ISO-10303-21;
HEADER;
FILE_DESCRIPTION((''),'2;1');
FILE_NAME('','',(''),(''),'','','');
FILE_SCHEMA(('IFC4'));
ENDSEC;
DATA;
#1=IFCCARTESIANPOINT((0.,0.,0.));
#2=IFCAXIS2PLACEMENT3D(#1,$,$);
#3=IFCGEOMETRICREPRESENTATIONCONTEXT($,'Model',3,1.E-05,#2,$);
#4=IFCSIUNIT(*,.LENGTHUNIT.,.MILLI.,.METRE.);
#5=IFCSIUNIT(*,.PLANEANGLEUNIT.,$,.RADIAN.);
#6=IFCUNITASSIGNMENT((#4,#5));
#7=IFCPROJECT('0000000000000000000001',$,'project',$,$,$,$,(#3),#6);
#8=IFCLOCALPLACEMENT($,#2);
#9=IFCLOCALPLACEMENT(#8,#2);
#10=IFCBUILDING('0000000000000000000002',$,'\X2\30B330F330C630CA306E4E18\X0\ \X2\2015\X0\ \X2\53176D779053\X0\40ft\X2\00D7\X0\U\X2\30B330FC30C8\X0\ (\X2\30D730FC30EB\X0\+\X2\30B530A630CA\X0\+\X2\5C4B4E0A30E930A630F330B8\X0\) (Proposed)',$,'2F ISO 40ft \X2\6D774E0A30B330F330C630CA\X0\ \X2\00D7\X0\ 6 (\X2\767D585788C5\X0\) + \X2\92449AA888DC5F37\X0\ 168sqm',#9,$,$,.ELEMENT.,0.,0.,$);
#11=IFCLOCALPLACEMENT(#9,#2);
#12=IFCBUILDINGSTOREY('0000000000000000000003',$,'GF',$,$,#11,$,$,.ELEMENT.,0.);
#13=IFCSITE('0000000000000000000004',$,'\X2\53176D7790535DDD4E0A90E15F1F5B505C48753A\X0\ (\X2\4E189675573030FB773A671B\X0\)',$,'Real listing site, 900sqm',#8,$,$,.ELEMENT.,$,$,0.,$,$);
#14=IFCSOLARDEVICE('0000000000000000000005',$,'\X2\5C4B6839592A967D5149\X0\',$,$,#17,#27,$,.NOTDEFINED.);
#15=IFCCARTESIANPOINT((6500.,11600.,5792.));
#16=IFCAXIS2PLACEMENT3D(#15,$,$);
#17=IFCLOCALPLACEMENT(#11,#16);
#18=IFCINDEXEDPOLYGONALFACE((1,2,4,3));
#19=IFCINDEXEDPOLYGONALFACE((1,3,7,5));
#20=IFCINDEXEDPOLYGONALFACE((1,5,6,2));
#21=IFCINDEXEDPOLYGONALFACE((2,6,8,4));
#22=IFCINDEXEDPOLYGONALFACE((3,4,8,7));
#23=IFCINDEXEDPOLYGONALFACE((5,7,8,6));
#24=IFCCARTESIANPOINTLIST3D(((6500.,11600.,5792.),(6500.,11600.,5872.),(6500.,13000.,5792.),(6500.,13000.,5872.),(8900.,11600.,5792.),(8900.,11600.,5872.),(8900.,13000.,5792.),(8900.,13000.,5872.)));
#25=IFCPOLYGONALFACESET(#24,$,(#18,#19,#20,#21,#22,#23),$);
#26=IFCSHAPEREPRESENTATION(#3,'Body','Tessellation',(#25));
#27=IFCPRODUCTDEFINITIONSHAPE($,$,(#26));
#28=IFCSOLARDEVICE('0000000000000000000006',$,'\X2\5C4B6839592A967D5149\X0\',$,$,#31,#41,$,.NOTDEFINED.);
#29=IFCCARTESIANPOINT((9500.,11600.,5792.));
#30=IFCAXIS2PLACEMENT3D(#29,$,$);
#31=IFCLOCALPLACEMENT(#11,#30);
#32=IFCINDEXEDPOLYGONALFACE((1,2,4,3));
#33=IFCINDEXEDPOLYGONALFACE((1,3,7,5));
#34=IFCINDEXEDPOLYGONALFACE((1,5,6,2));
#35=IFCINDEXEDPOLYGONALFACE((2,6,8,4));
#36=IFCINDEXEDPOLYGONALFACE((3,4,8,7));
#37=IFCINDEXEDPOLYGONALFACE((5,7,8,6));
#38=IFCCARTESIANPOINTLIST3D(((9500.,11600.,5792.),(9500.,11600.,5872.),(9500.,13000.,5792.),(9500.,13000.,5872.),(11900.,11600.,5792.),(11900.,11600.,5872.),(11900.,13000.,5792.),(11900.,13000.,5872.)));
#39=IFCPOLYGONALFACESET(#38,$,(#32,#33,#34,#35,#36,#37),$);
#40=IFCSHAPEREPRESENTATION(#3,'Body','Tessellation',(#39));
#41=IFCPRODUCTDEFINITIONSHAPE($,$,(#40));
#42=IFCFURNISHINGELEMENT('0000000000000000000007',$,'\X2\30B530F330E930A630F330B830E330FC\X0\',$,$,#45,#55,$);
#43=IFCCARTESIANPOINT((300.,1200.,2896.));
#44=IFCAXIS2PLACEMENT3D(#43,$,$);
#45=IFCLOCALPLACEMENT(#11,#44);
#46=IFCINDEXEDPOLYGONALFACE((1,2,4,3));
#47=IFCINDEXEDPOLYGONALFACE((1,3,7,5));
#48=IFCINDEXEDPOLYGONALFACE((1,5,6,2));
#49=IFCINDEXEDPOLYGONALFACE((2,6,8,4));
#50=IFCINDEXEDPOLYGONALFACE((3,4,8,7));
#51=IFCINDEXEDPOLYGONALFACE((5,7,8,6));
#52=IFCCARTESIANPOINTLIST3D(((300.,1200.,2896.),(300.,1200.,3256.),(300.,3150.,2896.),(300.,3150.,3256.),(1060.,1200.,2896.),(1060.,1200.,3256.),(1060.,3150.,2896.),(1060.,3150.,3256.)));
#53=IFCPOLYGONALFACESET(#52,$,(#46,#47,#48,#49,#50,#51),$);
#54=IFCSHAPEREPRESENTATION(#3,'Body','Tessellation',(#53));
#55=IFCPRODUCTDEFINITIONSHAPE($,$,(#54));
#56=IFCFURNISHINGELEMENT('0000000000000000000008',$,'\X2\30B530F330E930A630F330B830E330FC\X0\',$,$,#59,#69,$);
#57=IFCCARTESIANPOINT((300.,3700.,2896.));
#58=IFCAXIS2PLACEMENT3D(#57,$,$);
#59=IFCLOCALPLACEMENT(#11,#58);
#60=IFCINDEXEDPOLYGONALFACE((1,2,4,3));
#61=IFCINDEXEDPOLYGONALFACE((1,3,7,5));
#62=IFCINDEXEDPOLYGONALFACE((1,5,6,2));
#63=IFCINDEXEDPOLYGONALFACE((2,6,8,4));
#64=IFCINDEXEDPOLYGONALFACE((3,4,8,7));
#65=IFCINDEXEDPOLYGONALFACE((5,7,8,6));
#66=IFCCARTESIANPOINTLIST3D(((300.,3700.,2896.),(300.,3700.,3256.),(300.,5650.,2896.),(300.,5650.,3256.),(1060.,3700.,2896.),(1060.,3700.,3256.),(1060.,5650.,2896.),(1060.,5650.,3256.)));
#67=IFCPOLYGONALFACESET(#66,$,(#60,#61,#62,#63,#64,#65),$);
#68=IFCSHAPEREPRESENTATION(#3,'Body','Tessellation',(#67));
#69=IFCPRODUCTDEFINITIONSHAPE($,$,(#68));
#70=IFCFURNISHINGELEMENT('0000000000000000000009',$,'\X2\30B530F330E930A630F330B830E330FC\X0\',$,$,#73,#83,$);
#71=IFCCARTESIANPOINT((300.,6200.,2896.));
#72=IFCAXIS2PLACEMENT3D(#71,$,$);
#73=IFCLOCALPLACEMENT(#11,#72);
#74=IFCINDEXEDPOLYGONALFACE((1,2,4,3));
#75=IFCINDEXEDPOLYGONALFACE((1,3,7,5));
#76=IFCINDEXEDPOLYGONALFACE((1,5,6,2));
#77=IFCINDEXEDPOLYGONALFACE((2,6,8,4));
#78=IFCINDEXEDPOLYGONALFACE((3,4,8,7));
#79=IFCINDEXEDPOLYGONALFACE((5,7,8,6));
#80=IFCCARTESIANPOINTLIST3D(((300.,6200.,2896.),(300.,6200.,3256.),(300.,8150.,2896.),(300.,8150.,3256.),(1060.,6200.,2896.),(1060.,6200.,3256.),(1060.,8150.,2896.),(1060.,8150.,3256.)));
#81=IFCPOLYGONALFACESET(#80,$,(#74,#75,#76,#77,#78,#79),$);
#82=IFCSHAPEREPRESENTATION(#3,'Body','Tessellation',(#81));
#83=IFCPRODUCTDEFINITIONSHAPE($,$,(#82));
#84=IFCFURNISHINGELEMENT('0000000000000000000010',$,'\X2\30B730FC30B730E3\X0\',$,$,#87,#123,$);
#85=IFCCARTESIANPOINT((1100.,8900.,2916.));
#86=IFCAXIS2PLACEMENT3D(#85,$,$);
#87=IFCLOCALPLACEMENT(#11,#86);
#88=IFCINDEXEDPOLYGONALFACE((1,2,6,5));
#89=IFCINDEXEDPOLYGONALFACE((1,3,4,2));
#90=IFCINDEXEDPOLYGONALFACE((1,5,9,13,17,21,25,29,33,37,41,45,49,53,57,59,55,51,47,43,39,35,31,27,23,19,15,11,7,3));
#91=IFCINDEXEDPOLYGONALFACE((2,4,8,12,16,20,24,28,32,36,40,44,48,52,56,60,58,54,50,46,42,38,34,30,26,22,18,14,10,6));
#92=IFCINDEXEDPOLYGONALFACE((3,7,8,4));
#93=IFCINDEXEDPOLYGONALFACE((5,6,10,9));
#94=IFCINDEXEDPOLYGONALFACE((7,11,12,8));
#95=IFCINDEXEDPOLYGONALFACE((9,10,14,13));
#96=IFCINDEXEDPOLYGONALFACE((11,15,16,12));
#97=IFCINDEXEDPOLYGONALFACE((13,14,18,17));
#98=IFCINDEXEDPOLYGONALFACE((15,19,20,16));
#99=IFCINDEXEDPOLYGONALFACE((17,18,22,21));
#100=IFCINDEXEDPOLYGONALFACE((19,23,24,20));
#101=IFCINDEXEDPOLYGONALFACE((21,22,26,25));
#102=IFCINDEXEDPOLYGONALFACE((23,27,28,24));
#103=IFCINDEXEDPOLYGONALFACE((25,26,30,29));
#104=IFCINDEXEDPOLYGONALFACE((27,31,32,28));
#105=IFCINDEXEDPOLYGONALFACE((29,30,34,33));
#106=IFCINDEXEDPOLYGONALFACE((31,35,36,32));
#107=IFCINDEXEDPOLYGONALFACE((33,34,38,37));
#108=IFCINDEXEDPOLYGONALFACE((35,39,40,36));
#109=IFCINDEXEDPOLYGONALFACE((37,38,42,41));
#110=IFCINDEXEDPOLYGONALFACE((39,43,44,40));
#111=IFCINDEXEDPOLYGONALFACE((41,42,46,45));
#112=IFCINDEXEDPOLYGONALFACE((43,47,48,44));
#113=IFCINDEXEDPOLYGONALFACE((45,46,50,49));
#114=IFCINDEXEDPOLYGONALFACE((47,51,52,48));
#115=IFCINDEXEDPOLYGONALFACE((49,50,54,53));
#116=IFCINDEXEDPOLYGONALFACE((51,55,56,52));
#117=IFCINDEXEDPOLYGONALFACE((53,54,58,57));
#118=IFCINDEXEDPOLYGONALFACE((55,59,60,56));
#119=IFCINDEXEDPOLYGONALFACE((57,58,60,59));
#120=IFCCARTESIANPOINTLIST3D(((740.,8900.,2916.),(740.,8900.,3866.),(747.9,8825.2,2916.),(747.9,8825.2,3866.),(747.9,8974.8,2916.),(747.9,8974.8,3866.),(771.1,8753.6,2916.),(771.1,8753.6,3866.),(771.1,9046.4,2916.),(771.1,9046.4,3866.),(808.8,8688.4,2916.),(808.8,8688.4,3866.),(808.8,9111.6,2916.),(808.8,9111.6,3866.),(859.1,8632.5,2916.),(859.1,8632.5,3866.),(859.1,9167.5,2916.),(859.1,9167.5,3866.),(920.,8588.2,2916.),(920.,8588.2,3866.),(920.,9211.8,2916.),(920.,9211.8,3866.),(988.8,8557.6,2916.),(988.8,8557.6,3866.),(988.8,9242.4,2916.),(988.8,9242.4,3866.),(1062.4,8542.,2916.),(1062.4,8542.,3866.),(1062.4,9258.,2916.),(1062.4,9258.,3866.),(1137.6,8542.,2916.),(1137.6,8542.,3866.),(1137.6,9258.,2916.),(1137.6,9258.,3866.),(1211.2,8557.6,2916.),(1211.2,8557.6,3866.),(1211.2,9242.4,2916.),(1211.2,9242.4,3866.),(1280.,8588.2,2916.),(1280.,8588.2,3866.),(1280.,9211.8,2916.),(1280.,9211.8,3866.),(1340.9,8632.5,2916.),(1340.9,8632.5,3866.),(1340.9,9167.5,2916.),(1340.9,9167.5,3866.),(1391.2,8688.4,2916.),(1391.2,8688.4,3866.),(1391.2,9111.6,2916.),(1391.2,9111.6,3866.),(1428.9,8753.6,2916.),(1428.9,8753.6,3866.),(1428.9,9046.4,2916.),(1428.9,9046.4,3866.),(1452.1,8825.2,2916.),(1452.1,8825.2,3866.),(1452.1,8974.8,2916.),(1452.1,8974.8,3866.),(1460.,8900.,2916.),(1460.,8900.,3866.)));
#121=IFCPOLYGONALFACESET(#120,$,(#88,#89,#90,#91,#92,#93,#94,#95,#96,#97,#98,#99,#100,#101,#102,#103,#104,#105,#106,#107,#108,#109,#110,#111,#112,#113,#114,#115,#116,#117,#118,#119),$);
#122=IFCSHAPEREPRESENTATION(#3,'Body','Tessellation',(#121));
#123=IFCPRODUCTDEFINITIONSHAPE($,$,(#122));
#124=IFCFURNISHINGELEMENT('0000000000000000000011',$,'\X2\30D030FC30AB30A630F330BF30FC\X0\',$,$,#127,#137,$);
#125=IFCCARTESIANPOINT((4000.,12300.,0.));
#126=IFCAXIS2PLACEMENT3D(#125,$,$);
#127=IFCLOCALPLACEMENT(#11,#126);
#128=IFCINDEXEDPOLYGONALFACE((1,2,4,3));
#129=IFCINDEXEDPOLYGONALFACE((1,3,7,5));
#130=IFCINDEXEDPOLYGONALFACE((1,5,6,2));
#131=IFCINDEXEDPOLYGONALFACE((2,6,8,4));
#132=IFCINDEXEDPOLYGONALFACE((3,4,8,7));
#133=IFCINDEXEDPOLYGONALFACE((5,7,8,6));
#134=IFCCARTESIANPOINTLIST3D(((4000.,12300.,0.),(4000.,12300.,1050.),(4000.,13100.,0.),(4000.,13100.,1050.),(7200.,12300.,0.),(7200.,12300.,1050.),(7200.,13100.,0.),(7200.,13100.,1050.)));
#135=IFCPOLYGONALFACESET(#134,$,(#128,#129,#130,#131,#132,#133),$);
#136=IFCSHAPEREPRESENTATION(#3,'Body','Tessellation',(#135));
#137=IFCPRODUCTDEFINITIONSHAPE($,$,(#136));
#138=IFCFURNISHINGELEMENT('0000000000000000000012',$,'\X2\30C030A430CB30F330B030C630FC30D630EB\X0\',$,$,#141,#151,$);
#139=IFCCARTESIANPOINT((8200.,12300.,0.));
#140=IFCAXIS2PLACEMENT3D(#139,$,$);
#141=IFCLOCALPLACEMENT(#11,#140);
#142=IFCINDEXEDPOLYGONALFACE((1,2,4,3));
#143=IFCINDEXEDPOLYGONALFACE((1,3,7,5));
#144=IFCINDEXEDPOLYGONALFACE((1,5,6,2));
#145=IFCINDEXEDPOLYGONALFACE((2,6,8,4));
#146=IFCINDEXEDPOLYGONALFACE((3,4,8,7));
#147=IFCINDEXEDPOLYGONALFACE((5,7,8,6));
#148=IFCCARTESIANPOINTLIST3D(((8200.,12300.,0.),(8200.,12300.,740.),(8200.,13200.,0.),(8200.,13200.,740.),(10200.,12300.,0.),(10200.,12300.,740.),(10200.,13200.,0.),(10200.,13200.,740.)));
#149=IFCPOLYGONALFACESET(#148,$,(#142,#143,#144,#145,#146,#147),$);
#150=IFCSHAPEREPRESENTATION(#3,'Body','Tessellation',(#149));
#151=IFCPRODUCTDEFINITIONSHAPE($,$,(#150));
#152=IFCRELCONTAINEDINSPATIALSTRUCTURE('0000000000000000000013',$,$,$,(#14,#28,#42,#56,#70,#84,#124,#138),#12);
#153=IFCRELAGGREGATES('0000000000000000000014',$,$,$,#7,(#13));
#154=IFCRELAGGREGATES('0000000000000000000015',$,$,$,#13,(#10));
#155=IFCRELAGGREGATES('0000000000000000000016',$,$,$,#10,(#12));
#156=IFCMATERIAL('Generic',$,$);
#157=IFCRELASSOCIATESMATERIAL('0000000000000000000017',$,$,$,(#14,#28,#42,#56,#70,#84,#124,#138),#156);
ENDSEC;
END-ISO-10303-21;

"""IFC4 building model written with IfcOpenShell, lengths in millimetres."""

from ifc_helpers import new_model, si_unit, frame, frame_2d, origin, origin_2d, place, context, project, spatial, rectangle, circle, extrude, material, element, save


model = new_model("IFC4")

# Units and contexts
model_context = context("Model", 3, precision=1e-05, world=origin())
ifc_project = project(units=[si_unit("LENGTHUNIT", "METRE", prefix="MILLI"), si_unit("PLANEANGLEUNIT", "RADIAN")], contexts=[model_context])

# Site, building, storey
site_placement = place(None, origin())
site = spatial("IfcSite", under=ifc_project, at=site_placement, Name="北海道川上郡弟子屈町 (丘陵地・眺望)", ObjectType="Real listing site, 900sqm", CompositionType="ELEMENT", RefElevation=0.0)
building_placement = place(site_placement, origin())
building = spatial("IfcBuilding", under=site, at=building_placement, Name="コンテナの丘 ― 北海道40ft×Uコート (プール+サウナ+屋上ラウンジ) (Proposed)", ObjectType="2F ISO 40ft 海上コンテナ × 6 (白塗装) + 鉄骨補強 168sqm", CompositionType="ELEMENT", ElevationOfRefHeight=0.0, ElevationOfTerrain=0.0)
storey_placement = place(building_placement, origin())
storey = spatial("IfcBuildingStorey", under=building, at=storey_placement, Name="GF", CompositionType="ELEMENT", Elevation=0.0)

# Shared definitions
ifc_material = material(Name="Generic")

# Solar devices
solar_device_1_placement = place(storey_placement, frame((6500.0, 11600.0, 5792.0)))
element("IfcSolarDevice", 1, at=solar_device_1_placement, inside=storey, material=ifc_material, Name="屋根太陽光", PredefinedType="NOTDEFINED", context=model_context, shape_type="SweptSolid", body=[
    extrude(rectangle(XDim=2400.0, YDim=1400.0, at=frame_2d((1200.0, 700.0))), frame((6500.0, 11600.0, 5792.0)), (0.0, 0.0, 1.0), 80.0),
])
solar_device_2_placement = place(storey_placement, frame((9500.0, 11600.0, 5792.0)))
element("IfcSolarDevice", 2, at=solar_device_2_placement, inside=storey, material=ifc_material, Name="屋根太陽光", PredefinedType="NOTDEFINED", context=model_context, shape_type="SweptSolid", body=[
    extrude(rectangle(XDim=2400.0, YDim=1400.0, at=frame_2d((1200.0, 700.0))), frame((9500.0, 11600.0, 5792.0)), (0.0, 0.0, 1.0), 80.0),
])

# Furnishing elements
furnishing_1_placement = place(storey_placement, frame((300.0, 1200.0, 2896.0)))
element("IfcFurnishingElement", 3, at=furnishing_1_placement, inside=storey, material=ifc_material, Name="サンラウンジャー", context=model_context, shape_type="SweptSolid", body=[
    extrude(rectangle(XDim=760.0, YDim=1950.0, at=frame_2d((380.0, 975.0))), frame((300.0, 1200.0, 2896.0)), (0.0, 0.0, 1.0), 360.0),
])
furnishing_2_placement = place(storey_placement, frame((300.0, 3700.0, 2896.0)))
element("IfcFurnishingElement", 4, at=furnishing_2_placement, inside=storey, material=ifc_material, Name="サンラウンジャー", context=model_context, shape_type="SweptSolid", body=[
    extrude(rectangle(XDim=760.0, YDim=1950.0, at=frame_2d((380.0, 975.0))), frame((300.0, 3700.0, 2896.0)), (0.0, 0.0, 1.0), 360.0),
])
furnishing_3_placement = place(storey_placement, frame((300.0, 6200.0, 2896.0)))
element("IfcFurnishingElement", 5, at=furnishing_3_placement, inside=storey, material=ifc_material, Name="サンラウンジャー", context=model_context, shape_type="SweptSolid", body=[
    extrude(rectangle(XDim=760.0, YDim=1950.0, at=frame_2d((380.0, 975.0))), frame((300.0, 6200.0, 2896.0)), (0.0, 0.0, 1.0), 360.0),
])
furnishing_4_placement = place(storey_placement, frame((1100.0, 8900.0, 2916.0)))
element("IfcFurnishingElement", 6, at=furnishing_4_placement, inside=storey, material=ifc_material, Name="シーシャ", context=model_context, shape_type="SweptSolid", body=[
    extrude(circle(Radius=360.0, at=origin_2d()), frame((1100.0, 8900.0, 2916.0)), (0.0, 0.0, 1.0), 950.0),
])
furnishing_5_placement = place(storey_placement, frame((4000.0, 12300.0, 0.0)))
element("IfcFurnishingElement", 7, at=furnishing_5_placement, inside=storey, material=ifc_material, Name="バーカウンター", context=model_context, shape_type="SweptSolid", body=[
    extrude(rectangle(XDim=3200.0, YDim=800.0, at=frame_2d((1600.0, 400.0))), frame((4000.0, 12300.0, 0.0)), (0.0, 0.0, 1.0), 1050.0),
])
furnishing_6_placement = place(storey_placement, frame((8200.0, 12300.0, 0.0)))
element("IfcFurnishingElement", 8, at=furnishing_6_placement, inside=storey, material=ifc_material, Name="ダイニングテーブル", context=model_context, shape_type="SweptSolid", body=[
    extrude(rectangle(XDim=2000.0, YDim=900.0, at=frame_2d((1000.0, 450.0))), frame((8200.0, 12300.0, 0.0)), (0.0, 0.0, 1.0), 740.0),
])

save(model, "model.ifc")
